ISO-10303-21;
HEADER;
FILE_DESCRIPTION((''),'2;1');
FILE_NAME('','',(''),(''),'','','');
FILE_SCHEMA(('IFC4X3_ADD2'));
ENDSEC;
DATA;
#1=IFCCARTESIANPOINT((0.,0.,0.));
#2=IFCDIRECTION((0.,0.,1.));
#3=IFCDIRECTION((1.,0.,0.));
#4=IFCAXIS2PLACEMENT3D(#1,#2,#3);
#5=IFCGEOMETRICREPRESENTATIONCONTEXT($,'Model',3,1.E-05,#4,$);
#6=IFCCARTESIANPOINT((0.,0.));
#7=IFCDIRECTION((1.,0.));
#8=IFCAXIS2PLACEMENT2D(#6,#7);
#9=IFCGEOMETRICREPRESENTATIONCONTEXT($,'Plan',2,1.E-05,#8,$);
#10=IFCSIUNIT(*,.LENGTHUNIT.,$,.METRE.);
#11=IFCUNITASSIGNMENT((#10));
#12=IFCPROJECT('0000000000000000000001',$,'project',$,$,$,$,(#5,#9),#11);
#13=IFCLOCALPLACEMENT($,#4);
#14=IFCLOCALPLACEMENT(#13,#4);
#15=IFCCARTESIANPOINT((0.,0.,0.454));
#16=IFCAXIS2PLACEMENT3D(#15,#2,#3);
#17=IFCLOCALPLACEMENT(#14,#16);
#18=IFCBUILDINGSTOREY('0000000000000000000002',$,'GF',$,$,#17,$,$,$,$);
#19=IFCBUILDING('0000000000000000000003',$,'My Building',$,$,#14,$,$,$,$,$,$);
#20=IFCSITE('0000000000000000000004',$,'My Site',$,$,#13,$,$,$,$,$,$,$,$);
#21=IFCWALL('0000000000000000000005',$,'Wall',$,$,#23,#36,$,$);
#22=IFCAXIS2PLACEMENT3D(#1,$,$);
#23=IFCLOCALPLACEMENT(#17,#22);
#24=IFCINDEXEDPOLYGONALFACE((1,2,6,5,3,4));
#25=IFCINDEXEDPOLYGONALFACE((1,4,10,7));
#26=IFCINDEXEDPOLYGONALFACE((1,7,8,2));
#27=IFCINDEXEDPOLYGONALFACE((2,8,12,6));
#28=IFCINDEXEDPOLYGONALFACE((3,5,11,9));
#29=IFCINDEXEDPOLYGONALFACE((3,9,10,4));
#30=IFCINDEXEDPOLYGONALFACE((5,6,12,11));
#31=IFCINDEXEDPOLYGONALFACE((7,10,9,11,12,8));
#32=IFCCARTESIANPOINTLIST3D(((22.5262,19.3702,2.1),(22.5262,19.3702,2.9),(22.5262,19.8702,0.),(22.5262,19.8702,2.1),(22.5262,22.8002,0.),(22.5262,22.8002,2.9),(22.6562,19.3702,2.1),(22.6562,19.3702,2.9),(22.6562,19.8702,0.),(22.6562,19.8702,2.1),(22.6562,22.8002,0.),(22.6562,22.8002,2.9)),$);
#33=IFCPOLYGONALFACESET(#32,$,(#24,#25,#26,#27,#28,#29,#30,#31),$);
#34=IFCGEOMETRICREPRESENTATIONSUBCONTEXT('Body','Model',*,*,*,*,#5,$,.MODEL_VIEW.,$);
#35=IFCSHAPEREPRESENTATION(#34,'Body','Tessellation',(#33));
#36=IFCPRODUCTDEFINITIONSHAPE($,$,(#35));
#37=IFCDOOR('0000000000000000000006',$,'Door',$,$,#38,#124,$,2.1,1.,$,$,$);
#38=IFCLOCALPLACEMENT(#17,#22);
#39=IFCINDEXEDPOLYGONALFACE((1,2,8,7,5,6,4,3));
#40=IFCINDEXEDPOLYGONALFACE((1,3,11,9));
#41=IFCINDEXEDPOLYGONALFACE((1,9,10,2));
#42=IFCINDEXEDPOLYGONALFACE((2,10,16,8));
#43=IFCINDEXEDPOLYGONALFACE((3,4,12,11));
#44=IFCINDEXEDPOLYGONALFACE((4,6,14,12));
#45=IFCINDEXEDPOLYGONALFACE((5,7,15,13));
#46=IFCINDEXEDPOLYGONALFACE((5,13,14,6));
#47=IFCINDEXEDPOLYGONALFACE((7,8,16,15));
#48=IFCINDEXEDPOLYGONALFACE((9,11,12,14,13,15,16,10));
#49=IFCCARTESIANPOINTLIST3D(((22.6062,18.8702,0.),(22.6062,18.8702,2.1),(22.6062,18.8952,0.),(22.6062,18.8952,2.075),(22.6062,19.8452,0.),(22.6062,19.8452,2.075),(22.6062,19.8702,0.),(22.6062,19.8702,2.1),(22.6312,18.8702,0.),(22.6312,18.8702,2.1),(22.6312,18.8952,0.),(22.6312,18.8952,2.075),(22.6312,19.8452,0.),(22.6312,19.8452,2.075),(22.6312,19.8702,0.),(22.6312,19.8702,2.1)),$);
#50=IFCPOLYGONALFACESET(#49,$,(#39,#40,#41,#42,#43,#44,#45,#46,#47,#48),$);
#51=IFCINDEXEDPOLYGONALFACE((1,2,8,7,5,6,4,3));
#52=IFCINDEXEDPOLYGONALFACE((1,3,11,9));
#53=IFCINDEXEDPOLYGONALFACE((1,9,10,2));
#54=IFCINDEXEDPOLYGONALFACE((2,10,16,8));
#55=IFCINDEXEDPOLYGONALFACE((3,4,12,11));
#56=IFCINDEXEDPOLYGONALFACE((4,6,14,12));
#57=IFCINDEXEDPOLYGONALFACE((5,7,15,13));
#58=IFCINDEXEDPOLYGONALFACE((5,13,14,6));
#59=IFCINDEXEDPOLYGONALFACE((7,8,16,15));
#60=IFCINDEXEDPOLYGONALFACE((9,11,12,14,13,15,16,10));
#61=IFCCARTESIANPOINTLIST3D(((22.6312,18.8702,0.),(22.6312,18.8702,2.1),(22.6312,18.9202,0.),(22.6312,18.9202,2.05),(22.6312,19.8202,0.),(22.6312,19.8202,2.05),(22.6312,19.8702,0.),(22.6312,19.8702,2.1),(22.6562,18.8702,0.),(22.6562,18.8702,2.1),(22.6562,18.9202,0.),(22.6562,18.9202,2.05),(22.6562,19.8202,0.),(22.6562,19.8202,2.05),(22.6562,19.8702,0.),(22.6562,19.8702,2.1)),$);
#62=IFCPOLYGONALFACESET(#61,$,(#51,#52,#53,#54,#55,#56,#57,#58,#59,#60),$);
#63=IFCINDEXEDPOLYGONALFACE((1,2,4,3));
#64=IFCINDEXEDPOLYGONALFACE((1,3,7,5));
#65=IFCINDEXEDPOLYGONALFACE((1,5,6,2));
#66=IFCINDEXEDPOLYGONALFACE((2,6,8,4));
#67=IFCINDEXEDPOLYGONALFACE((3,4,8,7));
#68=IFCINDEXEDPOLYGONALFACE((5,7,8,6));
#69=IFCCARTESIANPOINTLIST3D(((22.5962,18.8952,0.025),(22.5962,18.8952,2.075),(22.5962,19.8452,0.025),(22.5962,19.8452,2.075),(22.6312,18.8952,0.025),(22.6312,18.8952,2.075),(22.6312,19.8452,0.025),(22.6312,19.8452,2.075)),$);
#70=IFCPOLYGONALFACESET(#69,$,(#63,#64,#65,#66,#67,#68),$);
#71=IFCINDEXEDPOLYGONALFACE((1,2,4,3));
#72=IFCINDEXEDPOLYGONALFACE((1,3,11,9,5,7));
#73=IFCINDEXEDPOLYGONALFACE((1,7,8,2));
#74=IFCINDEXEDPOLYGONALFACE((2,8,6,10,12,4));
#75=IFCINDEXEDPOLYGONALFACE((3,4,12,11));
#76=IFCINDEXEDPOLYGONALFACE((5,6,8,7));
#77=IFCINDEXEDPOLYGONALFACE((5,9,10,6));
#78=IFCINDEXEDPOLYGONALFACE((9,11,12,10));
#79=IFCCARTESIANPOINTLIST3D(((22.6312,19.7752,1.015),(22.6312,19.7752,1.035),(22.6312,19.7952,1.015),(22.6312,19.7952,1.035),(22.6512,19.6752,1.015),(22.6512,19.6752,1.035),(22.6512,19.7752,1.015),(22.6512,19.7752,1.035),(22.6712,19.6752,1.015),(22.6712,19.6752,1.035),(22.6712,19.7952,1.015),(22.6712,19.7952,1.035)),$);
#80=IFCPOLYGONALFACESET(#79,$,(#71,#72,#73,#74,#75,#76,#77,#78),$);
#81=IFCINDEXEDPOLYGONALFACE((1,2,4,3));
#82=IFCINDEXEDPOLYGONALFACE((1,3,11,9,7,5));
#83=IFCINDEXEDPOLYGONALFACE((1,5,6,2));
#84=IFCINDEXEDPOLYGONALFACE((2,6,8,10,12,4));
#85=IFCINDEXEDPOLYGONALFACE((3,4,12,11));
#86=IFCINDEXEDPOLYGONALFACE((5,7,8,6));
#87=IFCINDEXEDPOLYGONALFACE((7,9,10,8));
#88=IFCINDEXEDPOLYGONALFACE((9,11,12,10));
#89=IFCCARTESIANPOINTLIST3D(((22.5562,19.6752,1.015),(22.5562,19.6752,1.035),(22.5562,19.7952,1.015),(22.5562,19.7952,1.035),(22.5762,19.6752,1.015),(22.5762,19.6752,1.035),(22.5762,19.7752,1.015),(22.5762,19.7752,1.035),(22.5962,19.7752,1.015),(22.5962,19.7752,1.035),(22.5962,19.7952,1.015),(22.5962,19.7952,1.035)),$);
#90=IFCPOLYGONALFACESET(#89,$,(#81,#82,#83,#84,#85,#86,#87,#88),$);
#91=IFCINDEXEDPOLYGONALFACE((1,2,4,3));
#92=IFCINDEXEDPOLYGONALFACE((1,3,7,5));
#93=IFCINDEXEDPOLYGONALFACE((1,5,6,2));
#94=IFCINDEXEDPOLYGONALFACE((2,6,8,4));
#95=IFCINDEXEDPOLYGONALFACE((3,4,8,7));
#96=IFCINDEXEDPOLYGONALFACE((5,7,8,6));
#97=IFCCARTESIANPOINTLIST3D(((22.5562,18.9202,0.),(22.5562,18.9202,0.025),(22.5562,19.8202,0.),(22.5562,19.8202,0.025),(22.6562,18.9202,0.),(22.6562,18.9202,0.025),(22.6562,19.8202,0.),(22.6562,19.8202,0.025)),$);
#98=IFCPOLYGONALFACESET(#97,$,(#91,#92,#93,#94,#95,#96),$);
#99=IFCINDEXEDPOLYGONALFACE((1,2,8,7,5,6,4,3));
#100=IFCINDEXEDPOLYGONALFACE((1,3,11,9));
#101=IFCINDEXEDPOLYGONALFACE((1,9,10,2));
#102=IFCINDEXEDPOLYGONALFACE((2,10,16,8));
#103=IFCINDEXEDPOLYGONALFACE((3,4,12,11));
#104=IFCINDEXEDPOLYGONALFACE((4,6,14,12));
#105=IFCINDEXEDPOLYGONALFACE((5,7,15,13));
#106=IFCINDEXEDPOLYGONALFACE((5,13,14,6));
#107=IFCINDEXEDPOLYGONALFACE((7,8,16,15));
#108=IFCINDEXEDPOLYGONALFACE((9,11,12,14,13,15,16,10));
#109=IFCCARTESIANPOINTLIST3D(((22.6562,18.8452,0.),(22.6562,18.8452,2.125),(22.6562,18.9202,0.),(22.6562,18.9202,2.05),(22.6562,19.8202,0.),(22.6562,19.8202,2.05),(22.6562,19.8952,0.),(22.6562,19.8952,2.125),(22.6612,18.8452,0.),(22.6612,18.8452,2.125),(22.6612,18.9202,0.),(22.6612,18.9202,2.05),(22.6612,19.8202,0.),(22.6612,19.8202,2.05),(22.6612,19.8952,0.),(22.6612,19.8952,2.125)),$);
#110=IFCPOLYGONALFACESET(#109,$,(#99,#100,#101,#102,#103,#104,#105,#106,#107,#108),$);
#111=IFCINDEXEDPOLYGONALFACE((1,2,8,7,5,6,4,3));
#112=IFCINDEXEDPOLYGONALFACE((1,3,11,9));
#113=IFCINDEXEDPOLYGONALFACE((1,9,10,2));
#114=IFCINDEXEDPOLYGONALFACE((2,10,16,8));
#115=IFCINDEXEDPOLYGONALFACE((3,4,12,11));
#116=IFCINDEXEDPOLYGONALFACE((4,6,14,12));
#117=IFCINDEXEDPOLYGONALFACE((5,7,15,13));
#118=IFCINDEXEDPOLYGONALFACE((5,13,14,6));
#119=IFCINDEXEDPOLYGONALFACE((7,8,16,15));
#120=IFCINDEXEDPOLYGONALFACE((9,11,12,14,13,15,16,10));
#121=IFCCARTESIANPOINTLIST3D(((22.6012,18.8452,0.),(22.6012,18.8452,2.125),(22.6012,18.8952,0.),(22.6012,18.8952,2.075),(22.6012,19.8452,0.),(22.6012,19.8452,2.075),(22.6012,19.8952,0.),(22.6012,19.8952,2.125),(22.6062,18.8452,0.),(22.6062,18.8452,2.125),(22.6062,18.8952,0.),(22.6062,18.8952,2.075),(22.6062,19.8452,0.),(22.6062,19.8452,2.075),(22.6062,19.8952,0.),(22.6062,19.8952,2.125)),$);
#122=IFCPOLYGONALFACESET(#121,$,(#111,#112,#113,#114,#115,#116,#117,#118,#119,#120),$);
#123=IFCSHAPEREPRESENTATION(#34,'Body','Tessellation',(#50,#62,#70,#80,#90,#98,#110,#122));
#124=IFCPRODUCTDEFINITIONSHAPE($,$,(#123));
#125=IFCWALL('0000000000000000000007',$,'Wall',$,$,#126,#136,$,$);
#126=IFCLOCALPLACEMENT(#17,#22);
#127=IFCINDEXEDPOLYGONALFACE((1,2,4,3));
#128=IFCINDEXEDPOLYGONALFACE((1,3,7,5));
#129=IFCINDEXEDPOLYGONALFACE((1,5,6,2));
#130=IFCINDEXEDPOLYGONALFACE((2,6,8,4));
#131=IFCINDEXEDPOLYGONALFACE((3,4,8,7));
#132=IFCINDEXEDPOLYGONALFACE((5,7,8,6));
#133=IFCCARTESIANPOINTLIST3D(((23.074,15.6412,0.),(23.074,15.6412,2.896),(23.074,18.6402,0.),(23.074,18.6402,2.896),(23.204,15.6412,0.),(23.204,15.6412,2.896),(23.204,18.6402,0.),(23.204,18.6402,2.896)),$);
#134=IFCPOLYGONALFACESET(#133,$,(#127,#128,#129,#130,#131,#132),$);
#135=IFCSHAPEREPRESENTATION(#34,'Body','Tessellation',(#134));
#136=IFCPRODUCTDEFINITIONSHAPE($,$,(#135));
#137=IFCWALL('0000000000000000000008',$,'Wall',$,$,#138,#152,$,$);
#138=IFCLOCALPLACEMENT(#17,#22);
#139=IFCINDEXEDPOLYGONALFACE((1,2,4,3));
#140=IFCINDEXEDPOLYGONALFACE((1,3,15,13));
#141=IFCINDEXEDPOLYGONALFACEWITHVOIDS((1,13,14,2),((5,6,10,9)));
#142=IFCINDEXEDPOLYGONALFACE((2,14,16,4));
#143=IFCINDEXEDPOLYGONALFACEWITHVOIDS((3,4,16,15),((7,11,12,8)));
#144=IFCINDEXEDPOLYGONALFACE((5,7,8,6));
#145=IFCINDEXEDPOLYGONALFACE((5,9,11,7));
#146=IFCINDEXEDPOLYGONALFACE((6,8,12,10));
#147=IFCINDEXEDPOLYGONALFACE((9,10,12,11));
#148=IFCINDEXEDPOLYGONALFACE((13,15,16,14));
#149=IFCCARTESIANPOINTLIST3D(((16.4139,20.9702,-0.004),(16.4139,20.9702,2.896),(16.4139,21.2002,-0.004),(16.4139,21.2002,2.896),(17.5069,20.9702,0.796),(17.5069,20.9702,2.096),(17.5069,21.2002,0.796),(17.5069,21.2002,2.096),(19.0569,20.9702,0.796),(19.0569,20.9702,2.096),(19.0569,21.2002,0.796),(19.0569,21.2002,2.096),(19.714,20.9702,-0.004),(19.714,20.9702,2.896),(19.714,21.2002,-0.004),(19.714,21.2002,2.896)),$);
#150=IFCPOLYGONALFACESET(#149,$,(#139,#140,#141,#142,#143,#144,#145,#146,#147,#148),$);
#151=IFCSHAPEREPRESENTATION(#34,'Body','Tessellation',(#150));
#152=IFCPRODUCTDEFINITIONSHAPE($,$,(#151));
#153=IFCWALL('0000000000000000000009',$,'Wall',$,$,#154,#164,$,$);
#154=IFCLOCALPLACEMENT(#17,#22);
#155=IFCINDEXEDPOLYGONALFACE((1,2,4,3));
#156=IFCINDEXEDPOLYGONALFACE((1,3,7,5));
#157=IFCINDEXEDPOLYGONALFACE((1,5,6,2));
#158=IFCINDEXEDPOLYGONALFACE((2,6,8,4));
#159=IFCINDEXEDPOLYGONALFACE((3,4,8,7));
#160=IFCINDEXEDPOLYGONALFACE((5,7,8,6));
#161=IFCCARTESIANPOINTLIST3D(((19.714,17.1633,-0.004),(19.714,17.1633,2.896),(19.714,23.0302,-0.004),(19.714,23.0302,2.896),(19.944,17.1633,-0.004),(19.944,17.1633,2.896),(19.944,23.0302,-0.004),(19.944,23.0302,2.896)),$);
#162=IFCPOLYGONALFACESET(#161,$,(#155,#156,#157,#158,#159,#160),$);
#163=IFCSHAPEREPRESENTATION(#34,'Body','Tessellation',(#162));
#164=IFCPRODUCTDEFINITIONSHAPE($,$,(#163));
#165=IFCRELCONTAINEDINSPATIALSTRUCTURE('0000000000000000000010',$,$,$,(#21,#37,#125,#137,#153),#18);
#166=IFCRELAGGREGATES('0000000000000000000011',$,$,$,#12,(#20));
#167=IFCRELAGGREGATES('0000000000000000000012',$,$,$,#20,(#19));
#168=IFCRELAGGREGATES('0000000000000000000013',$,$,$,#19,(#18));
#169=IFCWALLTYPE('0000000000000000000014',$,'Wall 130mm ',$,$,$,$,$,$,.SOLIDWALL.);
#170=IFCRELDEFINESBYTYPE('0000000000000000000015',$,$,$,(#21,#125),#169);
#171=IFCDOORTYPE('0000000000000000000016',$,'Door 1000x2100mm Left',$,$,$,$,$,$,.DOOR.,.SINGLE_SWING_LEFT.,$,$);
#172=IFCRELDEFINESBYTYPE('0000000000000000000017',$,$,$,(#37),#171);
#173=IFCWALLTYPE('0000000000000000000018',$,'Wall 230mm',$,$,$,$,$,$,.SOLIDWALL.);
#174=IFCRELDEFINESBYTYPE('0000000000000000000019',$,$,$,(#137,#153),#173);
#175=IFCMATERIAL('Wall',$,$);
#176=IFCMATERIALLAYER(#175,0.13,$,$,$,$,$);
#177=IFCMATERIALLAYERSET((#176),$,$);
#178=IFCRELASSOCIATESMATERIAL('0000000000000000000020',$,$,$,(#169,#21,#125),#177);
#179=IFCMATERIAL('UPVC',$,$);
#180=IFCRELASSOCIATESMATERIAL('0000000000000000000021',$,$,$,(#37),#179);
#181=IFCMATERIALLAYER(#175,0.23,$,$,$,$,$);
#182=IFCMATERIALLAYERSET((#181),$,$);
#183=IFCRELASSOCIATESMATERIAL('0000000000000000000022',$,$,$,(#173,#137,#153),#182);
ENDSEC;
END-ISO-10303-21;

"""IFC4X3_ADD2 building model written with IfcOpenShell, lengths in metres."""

from ifc_helpers import new_model, entity, si_unit, frame, origin_with_axes, origin_2d_with_axis, place, context, subcontext, project, spatial, line, indexed_curve, outline, extrude, clip, halfspace, shape, source, transform, mapped, material, layer, layer_set, layer_usage, type_object, type_shapes, element, fill, save


model = new_model("IFC4X3_ADD2")

# Units and contexts
model_context = context("Model", 3, precision=1e-05, world=origin_with_axes())
plan_context = context("Plan", 2, precision=1e-05, world=origin_2d_with_axis())
body_context_1 = subcontext(model_context, "Body", "Model", "MODEL_VIEW")
body_context_2 = subcontext(plan_context, "Body", "Plan", "PLAN_VIEW")
ifc_project = project(units=[si_unit("LENGTHUNIT", "METRE")], contexts=[model_context, plan_context])

# Site, building, storey
site_placement = place(None, origin_with_axes())
site = spatial("IfcSite", under=ifc_project, at=site_placement, Name="My Site")
building_placement = place(site_placement, origin_with_axes())
building = spatial("IfcBuilding", under=site, at=building_placement, Name="My Building")
storey_placement = place(building_placement, frame((0.0, 0.0, 0.454), z_axis=(0.0, 0.0, 1.0), x_axis=(1.0, 0.0, 0.0)))
storey = spatial("IfcBuildingStorey", under=building, at=storey_placement, Name="GF")

# Shared definitions
ifc_material_1 = material(Name="UPVC")

# Shared definitions
ifc_material_2 = material(Name="Wall")
ifc_layer_1 = layer(ifc_material_2, 0.13)
ifc_layer_set_1 = layer_set([ifc_layer_1])
wall_type_1 = type_object("IfcWallType", Name="Wall 130mm ", PredefinedType="SOLIDWALL", material=ifc_layer_set_1)

# Wall, opening, door
ifc_layer_usage_1 = layer_usage(ifc_layer_set_1, "AXIS2", "POSITIVE", 0.0)
wall_1_placement = place(storey_placement, frame((22.6562, 19.3702, 0.0), z_axis=(0.0, 0.0, 1.0), x_axis=(0.000002, 1.0, 0.0)))
wall_1 = element("IfcWall", 1, at=wall_1_placement, inside=storey, type_object=wall_type_1, material=ifc_layer_usage_1, Name="Wall", context=body_context_1, shape_type="SweptSolid", body=[
    extrude(outline(indexed_curve([(0.0, 0.0), (0.0, 0.13), (3.43, 0.13), (3.43, 0.0), (0.0, 0.0)], self_intersect=False)), origin_with_axes(), (0.0, 0.0, 1.0), 2.9),
])
shared_shape_1 = source(origin_with_axes(), body_context_1, "Body", "SweptSolid", [
    extrude(outline(indexed_curve([(0.0, 0.0), (1.0, 0.0), (1.0, 2.1), (0.0, 2.1)], segments=[line(1, 2, 3, 4, 1)])), frame((0.0, -0.6, 0.0), z_axis=(0.0, -1.0, 0.0), x_axis=(1.0, 0.0, 0.0)), (0.0, 0.0, -1.0), 1.2),
])
opening_1_placement = place(wall_1_placement, frame((-0.5, 0.0, 0.0), z_axis=(0.0, 0.0, 1.0), x_axis=(1.0, 0.0, 0.0)))
opening_1 = element("IfcOpeningElement", 2, at=opening_1_placement, cuts=wall_1, PredefinedType="OPENING", context=body_context_1, shape_type="MappedRepresentation", body=[
    mapped(shared_shape_1, transform((0.0, 0.0, 0.0), x_axis=(1.0, 0.0, 0.0), y_axis=(0.0, 1.0, 0.0), z_axis=(0.0, 0.0, 1.0), scale=1.0)),
])
door_type_1 = type_object("IfcDoorType", Name="Door 1000x2100mm Left", OperationType="SINGLE_SWING_LEFT", PredefinedType="DOOR")
shared_shape_2 = source(origin_with_axes(), body_context_1, "Body", "SweptSolid", [
    extrude(outline(indexed_curve([(0.0, 0.0), (0.0, 2.1), (1.0, 2.1), (1.0, 0.0), (0.975, 0.0), (0.975, 2.075), (0.025, 2.075), (0.025, 0.0)], segments=[line(1, 2, 3, 4, 5, 6, 7, 8, 1)])), frame((0.0, 0.025, 0.0), z_axis=(0.0, -1.0, 0.0), x_axis=(1.0, 0.0, 0.0)), (0.0, 0.0, -1.0), 0.025),
    extrude(outline(indexed_curve([(0.0, 0.0), (0.0, 2.1), (1.0, 2.1), (1.0, 0.0), (0.95, 0.0), (0.95, 2.05), (0.05, 2.05), (0.05, 0.0)], segments=[line(1, 2, 3, 4, 5, 6, 7, 8, 1)])), frame((0.0, 0.0, 0.0), z_axis=(0.0, -1.0, 0.0), x_axis=(1.0, 0.0, 0.0)), (0.0, 0.0, -1.0), 0.025),
    extrude(outline(indexed_curve([(0.0, 0.0), (0.95, 0.0), (0.95, 0.035), (0.0, 0.035)], segments=[line(1, 2, 3, 4, 1)])), frame((0.025, 0.025, 0.025), z_axis=(0.0, 0.0, 1.0), x_axis=(1.0, 0.0, 0.0)), (0.0, 0.0, 1.0), 2.05),
    extrude(outline(indexed_curve([(0.0, 0.0), (0.0, -0.04), (-0.12, -0.04), (-0.12, -0.02), (-0.02, -0.02), (-0.02, 0.0)], segments=[line(1, 2, 3, 4, 5, 6, 1)])), frame((0.925, 0.025, 1.015), z_axis=(0.0, 0.0, 1.0), x_axis=(1.0, 0.0, 0.0)), (0.0, 0.0, 1.0), 0.02),
    extrude(outline(indexed_curve([(0.0, 0.0), (0.0, 0.04), (-0.12, 0.04), (-0.12, 0.02), (-0.02, 0.02), (-0.02, 0.0)], segments=[line(1, 2, 3, 4, 5, 6, 1)])), frame((0.925, 0.06, 1.015), z_axis=(0.0, 0.0, 1.0), x_axis=(1.0, 0.0, 0.0)), (0.0, 0.0, 1.0), 0.02),
    extrude(outline(indexed_curve([(0.0, 0.0), (0.9, 0.0), (0.9, 0.1), (0.0, 0.1)], segments=[line(1, 2, 3, 4, 1)])), frame((0.05, 0.0, 0.0), z_axis=(0.0, 0.0, 1.0), x_axis=(1.0, 0.0, 0.0)), (0.0, 0.0, 1.0), 0.025),
    extrude(outline(indexed_curve([(0.0, 0.0), (0.0, 2.125), (1.05, 2.125), (1.05, 0.0), (0.975, 0.0), (0.975, 2.05), (0.075, 2.05), (0.075, 0.0)], segments=[line(1, 2, 3, 4, 5, 6, 7, 8, 1)])), frame((-0.025, -0.005, 0.0), z_axis=(0.0, -1.0, 0.0), x_axis=(1.0, 0.0, 0.0)), (0.0, 0.0, -1.0), 0.005),
    extrude(outline(indexed_curve([(0.0, 0.0), (0.0, 2.125), (1.05, 2.125), (1.05, 0.0), (1.0, 0.0), (1.0, 2.075), (0.05, 2.075), (0.05, 0.0)], segments=[line(1, 2, 3, 4, 5, 6, 7, 8, 1)])), frame((-0.025, 0.05, 0.0), z_axis=(0.0, -1.0, 0.0), x_axis=(1.0, 0.0, 0.0)), (0.0, 0.0, -1.0), 0.005),
])
shared_shape_3 = source(origin_with_axes(), body_context_2, "Body", "Curve2D", [
    entity("IfcIndexedPolyCurve", entity("IfcCartesianPointList2D", [[0.0, 0.0], [0.0, 0.05], [0.025, 0.05], [0.025, 0.025], [0.05, 0.025], [0.05, 0.0]]), [entity("IfcLineIndex", [1, 2, 3, 4, 5, 6, 1])]),
    entity("IfcIndexedPolyCurve", entity("IfcCartesianPointList2D", [[1.0, 0.0], [1.0, 0.05], [0.975, 0.05], [0.975, 0.025], [0.95, 0.025], [0.95, 0.0]]), [entity("IfcLineIndex", [1, 2, 3, 4, 5, 6, 1])]),
    entity("IfcTrimmedCurve", entity("IfcEllipse", entity("IfcAxis2Placement2D", entity("IfcCartesianPoint", [0.06, 0.05]), entity("IfcDirection", [1.0, 0.0])), 0.915, 0.95), [entity("IfcCartesianPoint", [0.975, 0.05])], [entity("IfcCartesianPoint", [0.06, 1.0])], True, "CARTESIAN"),
    entity("IfcIndexedPolyCurve", entity("IfcCartesianPointList2D", [[0.025, 0.05], [0.06, 0.05], [0.06, 1.0], [0.025, 1.0]]), [entity("IfcLineIndex", [1, 2, 3, 4, 1])]),
])
type_shapes(door_type_1, [shared_shape_2, shared_shape_3])
door_1_placement = place(opening_1_placement, frame((0.0, 0.0, 0.0), z_axis=(0.0, 0.0, 1.0), x_axis=(1.0, 0.0, 0.0)))
door_1 = element("IfcDoor", 3, at=door_1_placement, inside=storey, type_object=door_type_1, material=ifc_material_1, Name="Door", OverallHeight=2.1, OverallWidth=1.0, shapes=[
    shape(body_context_1, "Body", "MappedRepresentation", [mapped(shared_shape_2, transform((0.0, 0.0, 0.0), x_axis=(1.0, 0.0, 0.0), y_axis=(0.0, 1.0, 0.0), z_axis=(0.0, 0.0, 1.0), scale=1.0))]),
    shape(body_context_2, "Body", "MappedRepresentation", [mapped(shared_shape_3, transform((0.0, 0.0, 0.0), x_axis=(1.0, 0.0, 0.0), y_axis=(0.0, 1.0, 0.0), z_axis=(0.0, 0.0, 1.0), scale=1.0))]),
])
fill(opening_1, door_1)

# Wall
ifc_layer_usage_2 = layer_usage(ifc_layer_set_1, "AXIS2", "POSITIVE", 0.0)
wall_2_placement = place(storey_placement, frame((23.204, 15.6412, 0.0), z_axis=(0.0, 0.0, 1.0), x_axis=(0.000001, 1.0, 0.0)))
element("IfcWall", 4, at=wall_2_placement, inside=storey, type_object=wall_type_1, material=ifc_layer_usage_2, Name="Wall", context=body_context_1, shape_type="Clipping", body=[
    clip(extrude(outline(indexed_curve([(0.0, 0.0), (0.0, 0.13), (2.999, 0.13), (2.999, 0.0), (0.0, 0.0)], self_intersect=False)), origin_with_axes(), (0.0, 0.0, 1.0), 3.35), halfspace(frame((0.0, 0.0, 2.896), z_axis=(0.0, 0.0, 1.0), x_axis=(-1.0, 0.0, 0.0)), False)),
])

# Wall, opening
ifc_layer_2 = layer(ifc_material_2, 0.23)
ifc_layer_set_2 = layer_set([ifc_layer_2])
ifc_layer_usage_3 = layer_usage(ifc_layer_set_2, "AXIS2", "POSITIVE", 0.0)
wall_type_2 = type_object("IfcWallType", Name="Wall 230mm", PredefinedType="SOLIDWALL", material=ifc_layer_set_2)
wall_3_placement = place(storey_placement, frame((19.714, 21.2002, -0.004), z_axis=(0.0, 0.0, 1.0), x_axis=(-1.0, 0.0, 0.0)))
wall_3 = element("IfcWall", 5, at=wall_3_placement, inside=storey, type_object=wall_type_2, material=ifc_layer_usage_3, Name="Wall", context=body_context_1, shape_type="SweptSolid", body=[
    extrude(outline(indexed_curve([(0.0, 0.0), (0.0, 0.23), (3.3, 0.23), (3.3, 0.0), (0.0, 0.0)], self_intersect=False)), origin_with_axes(), (0.0, 0.0, 1.0), 2.9),
])
shared_shape_4 = source(origin_with_axes(), body_context_1, "Body", "SweptSolid", [
    extrude(outline(indexed_curve([(0.0, 0.0), (1.55, 0.0), (1.55, 1.3), (0.0, 1.3)], segments=[line(1, 2, 3, 4, 1)])), frame((-0.775, -0.6, 0.0), z_axis=(0.0, -1.0, 0.0), x_axis=(1.0, 0.0, 0.0)), (0.0, 0.0, -1.0), 1.2),
])
opening_2_placement = place(wall_3_placement, frame((1.432, 0.0, 0.8), z_axis=(0.0, 0.0, 1.0), x_axis=(1.0, 0.0, 0.0)))
element("IfcOpeningElement", 6, at=opening_2_placement, cuts=wall_3, PredefinedType="OPENING", context=body_context_1, shape_type="MappedRepresentation", body=[
    mapped(shared_shape_4, transform((0.0, 0.0, 0.0), x_axis=(1.0, 0.0, 0.0), y_axis=(0.0, 1.0, 0.0), z_axis=(0.0, 0.0, 1.0), scale=1.0)),
])

# Wall
ifc_layer_usage_4 = layer_usage(ifc_layer_set_2, "AXIS2", "POSITIVE", 0.0)
wall_4_placement = place(storey_placement, frame((19.944, 17.1633, -0.004), z_axis=(0.0, 0.0, 1.0), x_axis=(0.000001, 1.0, 0.0)))
element("IfcWall", 7, at=wall_4_placement, inside=storey, type_object=wall_type_2, material=ifc_layer_usage_4, Name="Wall", context=body_context_1, shape_type="SweptSolid", body=[
    extrude(outline(indexed_curve([(0.0, 0.0), (0.0, 0.23), (5.8669, 0.23), (5.8669, 0.0), (0.0, 0.0)], self_intersect=False)), origin_with_axes(), (0.0, 0.0, 1.0), 2.9),
])

save(model, "model.ifc")
